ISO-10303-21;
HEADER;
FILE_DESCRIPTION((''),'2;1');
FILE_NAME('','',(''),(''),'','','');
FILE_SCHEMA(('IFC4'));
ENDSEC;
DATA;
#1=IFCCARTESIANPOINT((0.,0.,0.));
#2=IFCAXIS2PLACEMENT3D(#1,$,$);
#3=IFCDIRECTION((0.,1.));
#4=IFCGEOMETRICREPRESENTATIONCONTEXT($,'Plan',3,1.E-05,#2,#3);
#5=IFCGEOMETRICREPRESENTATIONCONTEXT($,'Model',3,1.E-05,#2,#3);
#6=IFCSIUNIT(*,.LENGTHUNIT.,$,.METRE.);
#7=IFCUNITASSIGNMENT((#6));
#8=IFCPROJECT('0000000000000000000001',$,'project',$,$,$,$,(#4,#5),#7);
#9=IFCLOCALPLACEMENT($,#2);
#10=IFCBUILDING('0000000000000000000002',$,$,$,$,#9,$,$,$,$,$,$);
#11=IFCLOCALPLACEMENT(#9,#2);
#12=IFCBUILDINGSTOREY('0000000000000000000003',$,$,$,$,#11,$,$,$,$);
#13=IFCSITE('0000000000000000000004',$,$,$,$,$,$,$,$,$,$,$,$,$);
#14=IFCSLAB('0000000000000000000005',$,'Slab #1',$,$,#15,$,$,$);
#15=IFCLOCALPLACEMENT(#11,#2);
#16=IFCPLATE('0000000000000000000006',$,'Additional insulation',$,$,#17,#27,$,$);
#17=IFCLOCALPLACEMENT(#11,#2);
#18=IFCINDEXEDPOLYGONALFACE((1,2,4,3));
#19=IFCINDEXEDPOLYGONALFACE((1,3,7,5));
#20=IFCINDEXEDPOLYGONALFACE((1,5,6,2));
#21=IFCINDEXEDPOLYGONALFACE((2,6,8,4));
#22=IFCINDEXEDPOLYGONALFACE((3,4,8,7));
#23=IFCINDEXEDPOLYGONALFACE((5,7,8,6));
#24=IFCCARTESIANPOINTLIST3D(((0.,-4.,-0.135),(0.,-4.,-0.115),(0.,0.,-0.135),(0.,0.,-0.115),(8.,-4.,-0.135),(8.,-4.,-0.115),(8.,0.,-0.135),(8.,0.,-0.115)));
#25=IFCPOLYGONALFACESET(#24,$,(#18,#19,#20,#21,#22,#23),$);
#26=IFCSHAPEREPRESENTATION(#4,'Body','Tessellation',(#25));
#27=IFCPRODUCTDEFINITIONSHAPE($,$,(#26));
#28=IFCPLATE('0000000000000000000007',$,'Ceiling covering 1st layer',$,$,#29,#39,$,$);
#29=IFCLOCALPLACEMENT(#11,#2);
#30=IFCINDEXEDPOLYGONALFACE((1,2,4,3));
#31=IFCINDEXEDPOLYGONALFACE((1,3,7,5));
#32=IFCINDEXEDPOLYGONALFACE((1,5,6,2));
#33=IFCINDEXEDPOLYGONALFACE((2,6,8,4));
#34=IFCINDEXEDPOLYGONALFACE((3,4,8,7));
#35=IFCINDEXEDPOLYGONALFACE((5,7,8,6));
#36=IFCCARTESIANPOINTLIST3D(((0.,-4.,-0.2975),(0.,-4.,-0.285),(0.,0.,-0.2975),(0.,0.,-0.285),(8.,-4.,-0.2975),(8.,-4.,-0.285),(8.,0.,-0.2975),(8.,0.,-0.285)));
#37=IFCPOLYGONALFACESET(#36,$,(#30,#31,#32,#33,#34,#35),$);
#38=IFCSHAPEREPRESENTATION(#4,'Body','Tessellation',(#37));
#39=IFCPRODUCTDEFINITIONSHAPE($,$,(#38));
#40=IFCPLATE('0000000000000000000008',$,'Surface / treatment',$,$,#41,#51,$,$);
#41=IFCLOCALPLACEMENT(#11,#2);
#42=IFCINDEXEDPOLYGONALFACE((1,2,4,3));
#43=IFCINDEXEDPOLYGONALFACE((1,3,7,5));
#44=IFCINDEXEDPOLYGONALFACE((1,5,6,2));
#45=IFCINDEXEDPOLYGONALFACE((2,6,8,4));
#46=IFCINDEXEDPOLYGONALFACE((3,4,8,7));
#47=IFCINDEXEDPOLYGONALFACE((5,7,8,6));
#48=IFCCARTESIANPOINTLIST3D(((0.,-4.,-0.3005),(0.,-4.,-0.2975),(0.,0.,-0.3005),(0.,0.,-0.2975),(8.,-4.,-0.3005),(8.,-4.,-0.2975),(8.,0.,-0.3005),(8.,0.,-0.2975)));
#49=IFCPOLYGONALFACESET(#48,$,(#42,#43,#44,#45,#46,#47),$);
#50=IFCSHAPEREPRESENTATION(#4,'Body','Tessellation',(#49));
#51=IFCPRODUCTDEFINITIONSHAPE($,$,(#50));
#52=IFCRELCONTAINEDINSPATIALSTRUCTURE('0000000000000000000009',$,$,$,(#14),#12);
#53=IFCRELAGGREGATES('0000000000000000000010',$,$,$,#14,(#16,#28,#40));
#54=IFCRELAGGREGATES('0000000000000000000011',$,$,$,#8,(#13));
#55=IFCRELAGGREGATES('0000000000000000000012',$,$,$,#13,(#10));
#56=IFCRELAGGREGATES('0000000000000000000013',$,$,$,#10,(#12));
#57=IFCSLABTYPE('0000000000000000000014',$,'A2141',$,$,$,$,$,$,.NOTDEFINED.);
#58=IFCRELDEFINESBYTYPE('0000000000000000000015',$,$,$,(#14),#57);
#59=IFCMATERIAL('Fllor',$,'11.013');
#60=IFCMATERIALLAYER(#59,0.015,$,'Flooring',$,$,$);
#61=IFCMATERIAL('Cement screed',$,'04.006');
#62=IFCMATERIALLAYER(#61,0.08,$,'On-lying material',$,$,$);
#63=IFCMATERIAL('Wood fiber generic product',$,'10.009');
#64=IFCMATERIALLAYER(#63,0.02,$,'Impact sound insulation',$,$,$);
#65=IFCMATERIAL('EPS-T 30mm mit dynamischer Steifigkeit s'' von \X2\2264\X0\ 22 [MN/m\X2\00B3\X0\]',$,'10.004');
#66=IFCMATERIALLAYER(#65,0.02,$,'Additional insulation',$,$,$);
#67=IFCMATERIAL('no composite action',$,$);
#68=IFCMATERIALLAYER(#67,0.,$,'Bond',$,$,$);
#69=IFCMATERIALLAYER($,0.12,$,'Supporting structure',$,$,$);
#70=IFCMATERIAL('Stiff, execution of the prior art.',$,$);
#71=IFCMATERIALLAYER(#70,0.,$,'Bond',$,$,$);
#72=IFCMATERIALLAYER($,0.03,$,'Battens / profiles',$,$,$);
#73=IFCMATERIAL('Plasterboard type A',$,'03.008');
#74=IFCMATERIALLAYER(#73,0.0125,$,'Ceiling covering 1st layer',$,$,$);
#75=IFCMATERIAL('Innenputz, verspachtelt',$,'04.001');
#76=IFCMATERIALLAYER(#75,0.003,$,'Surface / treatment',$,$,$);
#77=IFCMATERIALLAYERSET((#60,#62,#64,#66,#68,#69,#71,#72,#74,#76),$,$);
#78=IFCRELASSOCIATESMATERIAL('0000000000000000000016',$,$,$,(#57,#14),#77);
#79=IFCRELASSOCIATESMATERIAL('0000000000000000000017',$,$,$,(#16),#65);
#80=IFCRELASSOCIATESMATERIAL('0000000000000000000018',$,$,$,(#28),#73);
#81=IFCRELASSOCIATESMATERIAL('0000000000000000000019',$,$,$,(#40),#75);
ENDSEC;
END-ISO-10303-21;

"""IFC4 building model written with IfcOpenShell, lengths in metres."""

from ifc_helpers import new_model, si_unit, direction, frame, frame_2d, origin, place, context, project, spatial, rectangle, extrude, material, layer, layer_set, type_object, element, aggregate, save


model = new_model("IFC4")

# Units and contexts
plan_context = context("Plan", 3, precision=1e-05, world=origin(), true_north=direction((0.0, 1.0)))
model_context = context("Model", 3, precision=1e-05, world=origin(), true_north=direction((0.0, 1.0)))
ifc_project = project(units=[si_unit("LENGTHUNIT", "METRE")], contexts=[plan_context, model_context])

# Site, building, storey
site = spatial("IfcSite", under=ifc_project)
building_placement = place(None, origin())
building = spatial("IfcBuilding", under=site, at=building_placement)
storey_placement = place(building_placement, origin())
storey = spatial("IfcBuildingStorey", under=building, at=storey_placement)

# Slab, plates
ifc_material_1 = material(Name="Fllor", Category="11.013")
ifc_layer_1 = layer(ifc_material_1, 0.015, Name="Flooring")
ifc_material_2 = material(Name="Cement screed", Category="04.006")
ifc_layer_2 = layer(ifc_material_2, 0.08, Name="On-lying material")
ifc_material_3 = material(Name="Wood fiber generic product", Category="10.009")
ifc_layer_3 = layer(ifc_material_3, 0.02, Name="Impact sound insulation")
ifc_material_4 = material(Name="EPS-T 30mm mit dynamischer Steifigkeit s' von ≤ 22 [MN/m³]", Category="10.004")
ifc_layer_4 = layer(ifc_material_4, 0.02, Name="Additional insulation")
ifc_material_5 = material(Name="no composite action")
ifc_layer_5 = layer(ifc_material_5, 0.0, Name="Bond")
ifc_layer_6 = layer(None, 0.12, Name="Supporting structure")
ifc_material_6 = material(Name="Stiff, execution of the prior art.")
ifc_layer_7 = layer(ifc_material_6, 0.0, Name="Bond")
ifc_layer_8 = layer(None, 0.03, Name="Battens / profiles")
ifc_material_7 = material(Name="Plasterboard type A", Category="03.008")
ifc_layer_9 = layer(ifc_material_7, 0.0125, Name="Ceiling covering 1st layer")
ifc_material_8 = material(Name="Innenputz, verspachtelt", Category="04.001")
ifc_layer_10 = layer(ifc_material_8, 0.003, Name="Surface / treatment")
ifc_layer_set = layer_set([ifc_layer_1, ifc_layer_2, ifc_layer_3, ifc_layer_4, ifc_layer_5, ifc_layer_6, ifc_layer_7, ifc_layer_8, ifc_layer_9, ifc_layer_10])
slab_type = type_object("IfcSlabType", Name="A2141", PredefinedType="NOTDEFINED", material=ifc_layer_set)
slab_placement = place(None, frame((0.0, 0.0, 0.0), z_axis=(0.0, 0.0, -1.0), x_axis=(1.0, 0.0, 0.0)))
slab = element("IfcSlab", 1, at=slab_placement, inside=storey, type_object=slab_type, material=ifc_layer_set, Name="Slab #1")
plate_1_placement = place(slab_placement, origin())
plate_1 = element("IfcPlate", 2, at=plate_1_placement, material=ifc_material_4, Name="Additional insulation", context=plan_context, shape_type="SweptSolid", body=[
    extrude(rectangle(XDim=8.0, YDim=4.0, at=frame_2d((4.0, 2.0), x_axis=(1.0, 0.0))), frame((0.0, 0.0, 0.115), z_axis=(0.0, 0.0, 1.0), x_axis=(1.0, 0.0, 0.0)), (0.0, 0.0, 1.0), 0.02),
])
plate_2_placement = place(slab_placement, origin())
plate_2 = element("IfcPlate", 3, at=plate_2_placement, material=ifc_material_7, Name="Ceiling covering 1st layer", context=plan_context, shape_type="SweptSolid", body=[
    extrude(rectangle(XDim=8.0, YDim=4.0, at=frame_2d((4.0, 2.0), x_axis=(1.0, 0.0))), frame((0.0, 0.0, 0.285), z_axis=(0.0, 0.0, 1.0), x_axis=(1.0, 0.0, 0.0)), (0.0, 0.0, 1.0), 0.0125),
])
plate_3_placement = place(slab_placement, origin())
plate_3 = element("IfcPlate", 4, at=plate_3_placement, material=ifc_material_8, Name="Surface / treatment", context=plan_context, shape_type="SweptSolid", body=[
    extrude(rectangle(XDim=8.0, YDim=4.0, at=frame_2d((4.0, 2.0), x_axis=(1.0, 0.0))), frame((0.0, 0.0, 0.2975), z_axis=(0.0, 0.0, 1.0), x_axis=(1.0, 0.0, 0.0)), (0.0, 0.0, 1.0), 0.003),
])
aggregate(slab, [plate_1, plate_2, plate_3])

save(model, "model.ifc")
